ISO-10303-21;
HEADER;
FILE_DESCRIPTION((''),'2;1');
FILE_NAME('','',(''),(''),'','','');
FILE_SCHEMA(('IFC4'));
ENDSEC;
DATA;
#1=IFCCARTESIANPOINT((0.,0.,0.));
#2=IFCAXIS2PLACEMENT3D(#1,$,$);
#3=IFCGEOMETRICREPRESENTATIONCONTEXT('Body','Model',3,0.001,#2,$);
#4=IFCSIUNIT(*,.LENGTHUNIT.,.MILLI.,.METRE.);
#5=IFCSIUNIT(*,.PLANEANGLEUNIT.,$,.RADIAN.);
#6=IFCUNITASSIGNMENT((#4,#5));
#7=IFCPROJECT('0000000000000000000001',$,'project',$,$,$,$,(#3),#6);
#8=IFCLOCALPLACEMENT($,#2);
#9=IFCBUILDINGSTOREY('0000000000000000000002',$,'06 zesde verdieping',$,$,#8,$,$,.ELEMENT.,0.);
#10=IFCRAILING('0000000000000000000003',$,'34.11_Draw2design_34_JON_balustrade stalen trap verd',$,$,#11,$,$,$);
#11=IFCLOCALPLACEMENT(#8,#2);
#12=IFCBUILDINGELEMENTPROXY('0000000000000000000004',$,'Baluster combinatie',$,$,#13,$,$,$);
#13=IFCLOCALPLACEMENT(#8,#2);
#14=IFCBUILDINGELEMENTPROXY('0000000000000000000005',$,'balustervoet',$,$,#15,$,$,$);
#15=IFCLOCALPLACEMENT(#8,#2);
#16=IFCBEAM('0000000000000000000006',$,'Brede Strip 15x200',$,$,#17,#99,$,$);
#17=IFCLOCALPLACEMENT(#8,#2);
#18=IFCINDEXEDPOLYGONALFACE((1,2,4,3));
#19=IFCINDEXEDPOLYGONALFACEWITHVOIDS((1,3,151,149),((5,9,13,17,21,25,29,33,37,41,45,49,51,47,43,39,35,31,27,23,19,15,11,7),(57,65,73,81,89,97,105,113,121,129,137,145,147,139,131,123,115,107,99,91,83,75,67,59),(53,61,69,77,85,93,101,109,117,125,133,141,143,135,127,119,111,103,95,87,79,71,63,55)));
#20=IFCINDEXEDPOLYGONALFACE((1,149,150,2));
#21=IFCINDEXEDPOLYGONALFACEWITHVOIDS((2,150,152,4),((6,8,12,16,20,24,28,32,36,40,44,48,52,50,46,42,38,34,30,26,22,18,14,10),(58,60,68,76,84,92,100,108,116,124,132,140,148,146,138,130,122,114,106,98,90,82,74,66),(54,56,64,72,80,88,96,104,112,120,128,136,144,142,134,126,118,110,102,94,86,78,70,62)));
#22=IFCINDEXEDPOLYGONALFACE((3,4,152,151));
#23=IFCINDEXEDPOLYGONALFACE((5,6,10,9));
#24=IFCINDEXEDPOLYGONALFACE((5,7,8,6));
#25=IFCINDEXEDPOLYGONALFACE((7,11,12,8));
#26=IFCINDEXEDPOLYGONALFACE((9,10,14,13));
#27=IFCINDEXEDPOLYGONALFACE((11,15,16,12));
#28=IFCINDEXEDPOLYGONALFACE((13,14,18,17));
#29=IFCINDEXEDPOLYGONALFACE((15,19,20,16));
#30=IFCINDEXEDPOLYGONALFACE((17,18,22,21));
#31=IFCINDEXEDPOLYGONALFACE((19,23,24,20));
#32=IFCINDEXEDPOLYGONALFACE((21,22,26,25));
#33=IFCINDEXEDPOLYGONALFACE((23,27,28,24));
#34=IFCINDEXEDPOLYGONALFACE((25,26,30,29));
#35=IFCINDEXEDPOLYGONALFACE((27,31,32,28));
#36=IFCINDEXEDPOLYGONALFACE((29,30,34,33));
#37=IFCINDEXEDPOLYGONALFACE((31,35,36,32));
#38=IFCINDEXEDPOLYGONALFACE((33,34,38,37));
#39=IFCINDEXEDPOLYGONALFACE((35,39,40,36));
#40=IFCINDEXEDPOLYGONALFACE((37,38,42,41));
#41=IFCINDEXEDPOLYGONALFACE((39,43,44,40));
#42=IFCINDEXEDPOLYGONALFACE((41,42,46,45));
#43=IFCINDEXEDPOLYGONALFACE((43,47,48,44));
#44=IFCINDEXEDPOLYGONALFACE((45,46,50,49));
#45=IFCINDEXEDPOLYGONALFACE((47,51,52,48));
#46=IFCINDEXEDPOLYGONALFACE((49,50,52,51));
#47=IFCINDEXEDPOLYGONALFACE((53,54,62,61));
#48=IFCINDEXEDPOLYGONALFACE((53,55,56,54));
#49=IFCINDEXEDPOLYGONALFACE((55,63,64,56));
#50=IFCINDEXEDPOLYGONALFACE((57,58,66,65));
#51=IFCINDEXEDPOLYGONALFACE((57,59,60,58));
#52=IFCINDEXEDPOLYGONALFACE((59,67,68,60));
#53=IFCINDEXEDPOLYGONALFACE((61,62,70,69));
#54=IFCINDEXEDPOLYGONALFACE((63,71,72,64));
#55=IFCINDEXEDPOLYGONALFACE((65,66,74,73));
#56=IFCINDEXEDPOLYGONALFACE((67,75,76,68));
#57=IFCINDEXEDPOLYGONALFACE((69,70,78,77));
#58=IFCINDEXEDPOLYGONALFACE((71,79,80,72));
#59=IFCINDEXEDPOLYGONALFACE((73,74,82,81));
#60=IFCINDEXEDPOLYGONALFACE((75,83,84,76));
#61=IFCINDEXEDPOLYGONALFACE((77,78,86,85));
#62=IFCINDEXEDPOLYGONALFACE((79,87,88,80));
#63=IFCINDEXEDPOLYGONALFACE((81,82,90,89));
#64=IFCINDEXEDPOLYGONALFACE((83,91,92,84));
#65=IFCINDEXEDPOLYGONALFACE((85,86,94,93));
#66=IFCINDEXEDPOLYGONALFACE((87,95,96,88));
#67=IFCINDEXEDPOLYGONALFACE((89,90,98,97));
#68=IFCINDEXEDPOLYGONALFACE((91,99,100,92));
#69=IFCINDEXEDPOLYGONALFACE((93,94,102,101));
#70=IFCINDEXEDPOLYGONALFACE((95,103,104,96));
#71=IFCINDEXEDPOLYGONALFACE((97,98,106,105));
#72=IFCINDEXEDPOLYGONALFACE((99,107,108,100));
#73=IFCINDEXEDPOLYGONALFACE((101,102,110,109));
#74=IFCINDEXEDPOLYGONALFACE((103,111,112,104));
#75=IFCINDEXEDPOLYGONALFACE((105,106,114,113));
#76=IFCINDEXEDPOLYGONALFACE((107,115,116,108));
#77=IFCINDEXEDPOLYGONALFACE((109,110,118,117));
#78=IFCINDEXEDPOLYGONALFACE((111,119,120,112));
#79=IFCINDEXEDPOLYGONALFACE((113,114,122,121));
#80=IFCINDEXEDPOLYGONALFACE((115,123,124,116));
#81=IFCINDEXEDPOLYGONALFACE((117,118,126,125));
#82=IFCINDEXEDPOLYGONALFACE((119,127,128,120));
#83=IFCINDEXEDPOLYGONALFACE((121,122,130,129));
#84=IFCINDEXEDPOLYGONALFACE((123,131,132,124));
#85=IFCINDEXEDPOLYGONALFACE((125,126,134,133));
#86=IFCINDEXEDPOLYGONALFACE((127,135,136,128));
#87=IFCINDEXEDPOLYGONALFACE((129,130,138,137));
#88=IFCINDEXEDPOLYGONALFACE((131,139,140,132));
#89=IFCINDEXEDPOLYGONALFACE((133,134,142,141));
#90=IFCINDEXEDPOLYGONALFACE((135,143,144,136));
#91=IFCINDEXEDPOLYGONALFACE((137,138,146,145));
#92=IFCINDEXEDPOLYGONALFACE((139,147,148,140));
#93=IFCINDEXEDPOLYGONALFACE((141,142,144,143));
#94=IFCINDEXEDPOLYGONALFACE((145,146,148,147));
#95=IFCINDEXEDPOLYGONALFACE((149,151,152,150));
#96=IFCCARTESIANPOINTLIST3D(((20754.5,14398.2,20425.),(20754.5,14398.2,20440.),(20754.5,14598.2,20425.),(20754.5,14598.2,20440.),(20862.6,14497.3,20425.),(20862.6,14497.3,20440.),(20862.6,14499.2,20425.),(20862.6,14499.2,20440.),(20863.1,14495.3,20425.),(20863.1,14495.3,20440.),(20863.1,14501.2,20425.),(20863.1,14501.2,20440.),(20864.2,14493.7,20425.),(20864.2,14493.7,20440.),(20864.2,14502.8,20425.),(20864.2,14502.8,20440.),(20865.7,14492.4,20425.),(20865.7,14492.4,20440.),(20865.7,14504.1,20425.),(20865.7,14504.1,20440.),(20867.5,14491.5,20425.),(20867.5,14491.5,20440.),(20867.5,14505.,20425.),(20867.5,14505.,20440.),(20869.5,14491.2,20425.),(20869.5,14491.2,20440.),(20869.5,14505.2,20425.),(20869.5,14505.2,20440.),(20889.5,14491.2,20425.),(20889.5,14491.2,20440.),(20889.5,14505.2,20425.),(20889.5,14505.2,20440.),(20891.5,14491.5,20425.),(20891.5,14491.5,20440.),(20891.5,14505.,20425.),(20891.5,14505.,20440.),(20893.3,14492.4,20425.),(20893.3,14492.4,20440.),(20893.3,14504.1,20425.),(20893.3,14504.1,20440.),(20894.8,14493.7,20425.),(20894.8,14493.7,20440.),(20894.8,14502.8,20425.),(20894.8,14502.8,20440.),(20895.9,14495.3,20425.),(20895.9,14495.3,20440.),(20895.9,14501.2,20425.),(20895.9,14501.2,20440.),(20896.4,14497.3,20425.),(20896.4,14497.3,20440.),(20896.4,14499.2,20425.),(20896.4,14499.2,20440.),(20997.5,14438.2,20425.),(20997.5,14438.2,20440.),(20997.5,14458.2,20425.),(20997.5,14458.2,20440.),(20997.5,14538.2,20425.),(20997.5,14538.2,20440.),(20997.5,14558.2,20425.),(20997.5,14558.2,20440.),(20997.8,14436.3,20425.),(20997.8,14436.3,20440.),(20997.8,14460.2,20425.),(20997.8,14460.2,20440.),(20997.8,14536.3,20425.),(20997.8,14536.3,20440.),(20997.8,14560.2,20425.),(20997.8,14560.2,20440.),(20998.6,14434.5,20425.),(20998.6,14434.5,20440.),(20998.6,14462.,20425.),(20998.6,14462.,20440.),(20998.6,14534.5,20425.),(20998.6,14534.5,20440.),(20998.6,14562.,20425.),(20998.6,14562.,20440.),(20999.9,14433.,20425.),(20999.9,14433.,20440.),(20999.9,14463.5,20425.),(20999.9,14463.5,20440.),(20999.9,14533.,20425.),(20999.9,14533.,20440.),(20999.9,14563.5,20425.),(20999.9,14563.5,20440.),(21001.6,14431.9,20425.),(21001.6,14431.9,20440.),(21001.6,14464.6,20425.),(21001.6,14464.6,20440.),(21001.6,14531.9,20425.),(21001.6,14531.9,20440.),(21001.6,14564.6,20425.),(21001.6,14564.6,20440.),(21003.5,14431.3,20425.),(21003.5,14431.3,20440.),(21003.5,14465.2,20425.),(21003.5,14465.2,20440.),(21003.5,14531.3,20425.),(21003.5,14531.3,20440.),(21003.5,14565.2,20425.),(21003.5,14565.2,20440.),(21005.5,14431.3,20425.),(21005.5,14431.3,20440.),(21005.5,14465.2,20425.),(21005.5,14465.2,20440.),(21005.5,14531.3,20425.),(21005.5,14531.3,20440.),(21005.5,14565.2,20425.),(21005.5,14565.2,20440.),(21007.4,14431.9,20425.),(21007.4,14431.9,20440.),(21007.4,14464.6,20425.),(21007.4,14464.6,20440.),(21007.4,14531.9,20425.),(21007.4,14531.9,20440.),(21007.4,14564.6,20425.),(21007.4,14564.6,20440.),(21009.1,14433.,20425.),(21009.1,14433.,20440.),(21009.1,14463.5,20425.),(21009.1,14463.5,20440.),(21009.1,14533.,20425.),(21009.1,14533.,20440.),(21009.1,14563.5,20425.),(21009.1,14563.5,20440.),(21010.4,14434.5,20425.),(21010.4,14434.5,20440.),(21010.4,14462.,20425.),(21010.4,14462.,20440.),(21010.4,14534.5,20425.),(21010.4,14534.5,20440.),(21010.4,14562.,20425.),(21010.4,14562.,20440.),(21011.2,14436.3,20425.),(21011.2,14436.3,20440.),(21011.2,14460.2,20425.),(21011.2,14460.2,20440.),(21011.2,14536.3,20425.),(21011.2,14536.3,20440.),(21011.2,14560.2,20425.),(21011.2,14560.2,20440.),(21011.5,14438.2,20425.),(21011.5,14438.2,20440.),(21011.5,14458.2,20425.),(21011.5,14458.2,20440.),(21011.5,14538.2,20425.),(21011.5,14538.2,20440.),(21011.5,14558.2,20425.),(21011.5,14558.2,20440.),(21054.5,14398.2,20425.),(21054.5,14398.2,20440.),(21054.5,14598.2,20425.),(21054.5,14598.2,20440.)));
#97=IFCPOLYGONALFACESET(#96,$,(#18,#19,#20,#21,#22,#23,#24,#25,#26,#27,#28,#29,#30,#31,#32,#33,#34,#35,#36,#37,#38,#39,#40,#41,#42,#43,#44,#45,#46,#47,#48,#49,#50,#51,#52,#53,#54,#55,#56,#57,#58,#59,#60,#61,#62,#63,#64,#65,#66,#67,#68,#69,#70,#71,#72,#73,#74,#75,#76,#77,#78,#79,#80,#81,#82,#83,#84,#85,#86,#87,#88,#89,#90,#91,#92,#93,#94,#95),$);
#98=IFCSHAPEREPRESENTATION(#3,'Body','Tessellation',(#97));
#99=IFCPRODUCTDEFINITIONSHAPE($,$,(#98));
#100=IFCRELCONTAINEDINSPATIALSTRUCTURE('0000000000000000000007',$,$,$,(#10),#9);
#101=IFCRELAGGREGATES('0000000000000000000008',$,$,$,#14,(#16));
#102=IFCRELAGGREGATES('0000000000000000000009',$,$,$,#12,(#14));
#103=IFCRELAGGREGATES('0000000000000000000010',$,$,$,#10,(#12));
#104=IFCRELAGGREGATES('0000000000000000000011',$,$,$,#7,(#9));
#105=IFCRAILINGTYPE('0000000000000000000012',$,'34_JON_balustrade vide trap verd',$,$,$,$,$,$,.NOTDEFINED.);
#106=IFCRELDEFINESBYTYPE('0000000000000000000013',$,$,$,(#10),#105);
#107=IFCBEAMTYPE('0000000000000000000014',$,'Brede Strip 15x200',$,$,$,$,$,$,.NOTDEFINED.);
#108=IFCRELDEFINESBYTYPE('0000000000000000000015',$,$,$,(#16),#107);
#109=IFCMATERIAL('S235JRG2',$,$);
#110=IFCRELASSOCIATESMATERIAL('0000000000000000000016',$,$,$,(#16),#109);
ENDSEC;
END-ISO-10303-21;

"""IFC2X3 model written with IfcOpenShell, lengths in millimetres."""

from ifc_helpers import new_model, si_unit, point, frame, frame_2d, origin, origin_2d, place, context, project, spatial, circle_curve, line_curve, trimmed, segment, composite_curve, rectangle, outline, extrude, source, transform, mapped, material, type_object, element, aggregate, save


model = new_model("IFC2X3")

# Units and contexts
model_context = context("Model", 3, precision=0.001, world=origin(), identifier="Body")
ifc_project = project(units=[si_unit("LENGTHUNIT", "METRE", prefix="MILLI"), si_unit("PLANEANGLEUNIT", "RADIAN")], contexts=[model_context])

# Storey
storey_placement = place(None, origin())
storey = spatial("IfcBuildingStorey", under=ifc_project, at=storey_placement, Name="06 zesde verdieping", CompositionType="ELEMENT", Elevation=0.0)

# Railing, building element proxies, beam, openings
railing_type = type_object("IfcRailingType", Name="34_JON_balustrade vide trap verd")
railing_placement = place(storey_placement, frame((-1939.6, -29817.1, 74783.6)))
railing = element("IfcRailing", 1, at=railing_placement, inside=storey, type_object=railing_type, Name="34.11_Draw2design_34_JON_balustrade stalen trap verd")
proxy_1_placement = place(railing_placement, frame((22994.2, 44650.4, -54348.6), z_axis=(0.0, 0.0, 1.0), x_axis=(0.0, 1.0, 0.0)))
proxy_1 = element("IfcBuildingElementProxy", 2, at=proxy_1_placement, Name="Baluster combinatie")
ifc_material_1 = material(Name="S235JRG2")
proxy_2_placement = place(proxy_1_placement, frame((-45247.5, 21054.5, -49235.0), z_axis=(0.0, 0.0, 1.0), x_axis=(0.0, -1.0, 0.0)))
proxy_2 = element("IfcBuildingElementProxy", 3, at=proxy_2_placement, Name="balustervoet")
beam_type_1 = type_object("IfcBeamType", Name="Brede Strip 15x200")
shared_shape_1 = source(origin(), model_context, "Body", "SweptSolid", [
    extrude(rectangle(XDim=15.0, YDim=200.0, at=origin_2d()), origin(), (0.0, 0.0, -1.0), 300.0),
])
beam_1_placement = place(proxy_2_placement, frame((21054.5, 44912.5, 49232.5), z_axis=(1.0, 0.0, 0.0), x_axis=(0.0, 0.0, 1.0)))
beam_1 = element("IfcBeam", 4, at=beam_1_placement, type_object=beam_type_1, material=ifc_material_1, Name="Brede Strip 15x200", context=model_context, shape_type="MappedRepresentation", body=[
    mapped(shared_shape_1, transform((0.0, 0.0, 0.0), scale=1.0)),
])
opening_1_placement = place(beam_1_placement, frame((7.5, 0.0, -175.0), z_axis=(-1.0, 0.0, 0.0), x_axis=(0.0, 0.0, -1.0)))
element("IfcOpeningElement", 5, at=opening_1_placement, cuts=beam_1, ObjectType="Opening", context=model_context, shape_type="SweptSolid", body=[
    extrude(outline(composite_curve([segment(trimmed(circle_curve(frame_2d((10.0, 0.0), x_axis=(0.0, -1.0)), 7.0), [point((10.0, 7.0))], [point((10.0, -7.0))], False, "CARTESIAN"), True, "CONTINUOUS"), segment(trimmed(line_curve((10.0, -7.0), (-20.0, 0.0), 20.0), [point((10.0, -7.0))], [point((-10.0, -7.0))], True, "CARTESIAN"), True, "CONTINUOUS"), segment(trimmed(circle_curve(frame_2d((-10.0, 0.0), x_axis=(0.0, -1.0)), 7.0), [point((-10.0, -7.0))], [point((-10.0, 7.0))], False, "CARTESIAN"), True, "CONTINUOUS"), segment(trimmed(line_curve((-10.0, 7.0), (20.0, 0.0), 20.0), [point((-10.0, 7.0))], [point((10.0, 7.0))], True, "CARTESIAN"), True, "CONTINUOUS")], self_intersect=False)), origin(), (0.0, 0.0, 1.0), 15.0),
])
opening_2_placement = place(beam_1_placement, frame((7.5, -50.0, -50.0), z_axis=(-1.0, 0.0, 0.0), x_axis=(0.0, -1.0, 0.0)))
element("IfcOpeningElement", 6, at=opening_2_placement, cuts=beam_1, ObjectType="Opening", context=model_context, shape_type="SweptSolid", body=[
    extrude(outline(composite_curve([segment(trimmed(circle_curve(frame_2d((10.0, 0.0), x_axis=(0.0, -1.0)), 7.0), [point((10.0, 7.0))], [point((10.0, -7.0))], False, "CARTESIAN"), True, "CONTINUOUS"), segment(trimmed(line_curve((10.0, -7.0), (-20.0, 0.0), 20.0), [point((10.0, -7.0))], [point((-10.0, -7.0))], True, "CARTESIAN"), True, "CONTINUOUS"), segment(trimmed(circle_curve(frame_2d((-10.0, 0.0), x_axis=(0.0, -1.0)), 7.0), [point((-10.0, -7.0))], [point((-10.0, 7.0))], False, "CARTESIAN"), True, "CONTINUOUS"), segment(trimmed(line_curve((-10.0, 7.0), (20.0, 0.0), 20.0), [point((-10.0, 7.0))], [point((10.0, 7.0))], True, "CARTESIAN"), True, "CONTINUOUS")], self_intersect=False)), origin(), (0.0, 0.0, 1.0), 15.0),
])
opening_3_placement = place(beam_1_placement, frame((7.5, 50.0, -50.0), z_axis=(-1.0, 0.0, 0.0), x_axis=(0.0, -1.0, 0.0)))
element("IfcOpeningElement", 7, at=opening_3_placement, cuts=beam_1, ObjectType="Opening", context=model_context, shape_type="SweptSolid", body=[
    extrude(outline(composite_curve([segment(trimmed(circle_curve(frame_2d((10.0, 0.0), x_axis=(0.0, -1.0)), 7.0), [point((10.0, 7.0))], [point((10.0, -7.0))], False, "CARTESIAN"), True, "CONTINUOUS"), segment(trimmed(line_curve((10.0, -7.0), (-20.0, 0.0), 20.0), [point((10.0, -7.0))], [point((-10.0, -7.0))], True, "CARTESIAN"), True, "CONTINUOUS"), segment(trimmed(circle_curve(frame_2d((-10.0, 0.0), x_axis=(0.0, -1.0)), 7.0), [point((-10.0, -7.0))], [point((-10.0, 7.0))], False, "CARTESIAN"), True, "CONTINUOUS"), segment(trimmed(line_curve((-10.0, 7.0), (20.0, 0.0), 20.0), [point((-10.0, 7.0))], [point((10.0, 7.0))], True, "CARTESIAN"), True, "CONTINUOUS")], self_intersect=False)), origin(), (0.0, 0.0, 1.0), 15.0),
])
aggregate(proxy_2, [beam_1])
aggregate(proxy_1, [proxy_2])
aggregate(railing, [proxy_1])

save(model, "model.ifc")
